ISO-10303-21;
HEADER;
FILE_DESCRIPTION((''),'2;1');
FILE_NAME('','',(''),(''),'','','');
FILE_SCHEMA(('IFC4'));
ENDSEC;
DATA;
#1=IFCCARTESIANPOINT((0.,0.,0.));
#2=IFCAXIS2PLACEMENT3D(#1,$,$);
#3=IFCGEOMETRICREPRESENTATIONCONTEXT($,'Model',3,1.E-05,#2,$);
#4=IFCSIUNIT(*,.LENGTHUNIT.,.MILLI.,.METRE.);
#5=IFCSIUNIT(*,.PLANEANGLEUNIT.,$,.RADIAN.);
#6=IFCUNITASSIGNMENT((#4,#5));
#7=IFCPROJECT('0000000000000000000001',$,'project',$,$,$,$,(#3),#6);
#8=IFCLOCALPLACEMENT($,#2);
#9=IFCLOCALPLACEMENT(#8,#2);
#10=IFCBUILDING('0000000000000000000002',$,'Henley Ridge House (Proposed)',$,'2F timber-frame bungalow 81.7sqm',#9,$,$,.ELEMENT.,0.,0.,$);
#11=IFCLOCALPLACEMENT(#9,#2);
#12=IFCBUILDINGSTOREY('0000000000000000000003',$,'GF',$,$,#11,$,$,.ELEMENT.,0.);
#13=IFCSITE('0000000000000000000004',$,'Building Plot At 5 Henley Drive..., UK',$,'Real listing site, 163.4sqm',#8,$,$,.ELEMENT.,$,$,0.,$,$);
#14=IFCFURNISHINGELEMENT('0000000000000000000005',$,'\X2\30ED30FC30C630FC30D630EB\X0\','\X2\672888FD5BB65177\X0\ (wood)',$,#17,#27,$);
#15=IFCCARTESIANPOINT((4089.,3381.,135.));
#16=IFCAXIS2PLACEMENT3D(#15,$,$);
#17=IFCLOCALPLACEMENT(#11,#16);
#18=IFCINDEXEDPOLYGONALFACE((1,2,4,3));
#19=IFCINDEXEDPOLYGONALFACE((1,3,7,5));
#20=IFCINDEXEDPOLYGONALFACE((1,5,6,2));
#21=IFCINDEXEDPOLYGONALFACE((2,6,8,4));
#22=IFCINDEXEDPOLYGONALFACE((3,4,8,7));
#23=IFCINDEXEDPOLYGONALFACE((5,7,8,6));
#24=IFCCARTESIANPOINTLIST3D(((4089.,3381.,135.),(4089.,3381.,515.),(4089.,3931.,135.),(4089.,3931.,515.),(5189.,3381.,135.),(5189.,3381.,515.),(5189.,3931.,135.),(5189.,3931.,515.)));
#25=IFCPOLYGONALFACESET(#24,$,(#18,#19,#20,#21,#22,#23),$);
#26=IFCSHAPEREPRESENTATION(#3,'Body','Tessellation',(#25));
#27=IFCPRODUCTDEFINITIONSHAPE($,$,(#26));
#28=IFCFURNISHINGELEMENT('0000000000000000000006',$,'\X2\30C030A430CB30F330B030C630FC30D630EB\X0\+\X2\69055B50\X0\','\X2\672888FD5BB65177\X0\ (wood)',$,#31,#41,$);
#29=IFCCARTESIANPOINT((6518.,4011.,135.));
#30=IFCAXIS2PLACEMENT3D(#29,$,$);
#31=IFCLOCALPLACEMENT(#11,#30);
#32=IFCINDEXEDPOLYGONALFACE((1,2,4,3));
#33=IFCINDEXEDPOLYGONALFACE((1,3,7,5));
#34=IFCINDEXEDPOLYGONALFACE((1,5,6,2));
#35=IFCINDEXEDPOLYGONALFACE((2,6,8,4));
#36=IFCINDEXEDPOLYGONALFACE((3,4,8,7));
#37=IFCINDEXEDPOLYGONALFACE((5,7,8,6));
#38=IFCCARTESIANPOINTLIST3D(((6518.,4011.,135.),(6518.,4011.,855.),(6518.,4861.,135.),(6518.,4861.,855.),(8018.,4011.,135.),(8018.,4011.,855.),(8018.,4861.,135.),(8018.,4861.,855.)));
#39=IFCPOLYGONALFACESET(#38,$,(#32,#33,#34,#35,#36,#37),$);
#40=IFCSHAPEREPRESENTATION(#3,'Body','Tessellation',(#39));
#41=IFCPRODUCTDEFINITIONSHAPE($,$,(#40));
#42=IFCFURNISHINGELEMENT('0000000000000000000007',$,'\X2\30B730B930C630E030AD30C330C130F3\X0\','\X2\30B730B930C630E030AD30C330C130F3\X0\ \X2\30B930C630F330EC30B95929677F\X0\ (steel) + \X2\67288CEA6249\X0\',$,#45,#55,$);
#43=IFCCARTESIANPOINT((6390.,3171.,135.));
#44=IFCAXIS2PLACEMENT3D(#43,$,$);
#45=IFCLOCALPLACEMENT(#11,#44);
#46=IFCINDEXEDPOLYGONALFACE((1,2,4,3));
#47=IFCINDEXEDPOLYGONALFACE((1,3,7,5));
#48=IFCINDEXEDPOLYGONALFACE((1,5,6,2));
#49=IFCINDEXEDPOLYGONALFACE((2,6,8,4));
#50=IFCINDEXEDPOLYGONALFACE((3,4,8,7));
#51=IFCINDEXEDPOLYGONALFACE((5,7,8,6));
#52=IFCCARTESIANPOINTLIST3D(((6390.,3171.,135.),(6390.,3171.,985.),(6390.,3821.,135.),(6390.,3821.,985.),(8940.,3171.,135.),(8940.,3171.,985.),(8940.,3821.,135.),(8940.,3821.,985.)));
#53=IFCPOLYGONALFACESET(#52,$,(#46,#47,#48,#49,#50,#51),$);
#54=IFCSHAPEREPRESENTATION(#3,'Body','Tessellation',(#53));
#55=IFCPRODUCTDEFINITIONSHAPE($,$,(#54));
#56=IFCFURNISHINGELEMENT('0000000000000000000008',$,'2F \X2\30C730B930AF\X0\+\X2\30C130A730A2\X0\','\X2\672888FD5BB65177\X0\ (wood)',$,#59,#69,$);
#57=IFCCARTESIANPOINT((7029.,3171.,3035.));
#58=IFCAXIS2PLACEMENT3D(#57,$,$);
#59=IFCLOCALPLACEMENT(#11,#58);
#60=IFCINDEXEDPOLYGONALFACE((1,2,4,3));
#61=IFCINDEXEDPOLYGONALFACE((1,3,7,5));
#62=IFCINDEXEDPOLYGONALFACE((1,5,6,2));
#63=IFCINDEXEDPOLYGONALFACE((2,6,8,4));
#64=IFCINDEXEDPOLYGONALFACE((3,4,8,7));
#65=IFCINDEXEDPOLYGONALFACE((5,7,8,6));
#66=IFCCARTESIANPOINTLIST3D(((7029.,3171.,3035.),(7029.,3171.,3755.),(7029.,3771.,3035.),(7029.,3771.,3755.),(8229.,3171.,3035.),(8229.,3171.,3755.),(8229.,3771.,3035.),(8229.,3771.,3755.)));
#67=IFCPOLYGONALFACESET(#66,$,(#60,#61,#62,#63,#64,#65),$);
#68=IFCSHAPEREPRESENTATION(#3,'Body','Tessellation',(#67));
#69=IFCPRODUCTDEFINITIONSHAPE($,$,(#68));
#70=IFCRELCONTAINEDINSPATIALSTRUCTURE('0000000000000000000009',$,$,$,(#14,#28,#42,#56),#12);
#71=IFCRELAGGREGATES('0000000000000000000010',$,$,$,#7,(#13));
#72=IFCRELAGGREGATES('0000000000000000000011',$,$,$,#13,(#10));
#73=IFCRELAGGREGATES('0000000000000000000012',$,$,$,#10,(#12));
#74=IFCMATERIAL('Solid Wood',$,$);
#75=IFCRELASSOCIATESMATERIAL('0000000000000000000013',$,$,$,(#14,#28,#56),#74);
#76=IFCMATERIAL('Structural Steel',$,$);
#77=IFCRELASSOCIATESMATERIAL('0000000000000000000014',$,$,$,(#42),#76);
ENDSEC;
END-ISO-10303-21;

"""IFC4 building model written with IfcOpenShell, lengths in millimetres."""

from ifc_helpers import new_model, si_unit, frame, frame_2d, origin, place, context, project, spatial, rectangle, extrude, material, element, save


model = new_model("IFC4")

# Units and contexts
model_context = context("Model", 3, precision=1e-05, world=origin())
ifc_project = project(units=[si_unit("LENGTHUNIT", "METRE", prefix="MILLI"), si_unit("PLANEANGLEUNIT", "RADIAN")], contexts=[model_context])

# Site, building, storey
site_placement = place(None, origin())
site = spatial("IfcSite", under=ifc_project, at=site_placement, Name="Building Plot At 5 Henley Drive..., UK", ObjectType="Real listing site, 163.4sqm", CompositionType="ELEMENT", RefElevation=0.0)
building_placement = place(site_placement, origin())
building = spatial("IfcBuilding", under=site, at=building_placement, Name="Henley Ridge House (Proposed)", ObjectType="2F timber-frame bungalow 81.7sqm", CompositionType="ELEMENT", ElevationOfRefHeight=0.0, ElevationOfTerrain=0.0)
storey_placement = place(building_placement, origin())
storey = spatial("IfcBuildingStorey", under=building, at=storey_placement, Name="GF", CompositionType="ELEMENT", Elevation=0.0)

# Shared definitions
ifc_material_1 = material(Name="Solid Wood")

# Shared definitions
ifc_material_2 = material(Name="Structural Steel")

# Furnishing elements
furnishing_1_placement = place(storey_placement, frame((4089.0, 3381.0, 135.0)))
element("IfcFurnishingElement", 1, at=furnishing_1_placement, inside=storey, material=ifc_material_1, Name="ローテーブル", Description="木製家具 (wood)", context=model_context, shape_type="SweptSolid", body=[
    extrude(rectangle(XDim=1100.0, YDim=550.0, at=frame_2d((550.0, 275.0))), frame((4089.0, 3381.0, 135.0)), (0.0, 0.0, 1.0), 380.0),
])
furnishing_2_placement = place(storey_placement, frame((6518.0, 4011.0, 135.0)))
element("IfcFurnishingElement", 2, at=furnishing_2_placement, inside=storey, material=ifc_material_1, Name="ダイニングテーブル+椅子", Description="木製家具 (wood)", context=model_context, shape_type="SweptSolid", body=[
    extrude(rectangle(XDim=1500.0, YDim=850.0, at=frame_2d((750.0, 425.0))), frame((6518.0, 4011.0, 135.0)), (0.0, 0.0, 1.0), 720.0),
])
furnishing_3_placement = place(storey_placement, frame((6390.0, 3171.0, 135.0)))
element("IfcFurnishingElement", 3, at=furnishing_3_placement, inside=storey, material=ifc_material_2, Name="システムキッチン", Description="システムキッチン ステンレス天板 (steel) + 木質扉", context=model_context, shape_type="SweptSolid", body=[
    extrude(rectangle(XDim=2550.0, YDim=650.0, at=frame_2d((1275.0, 325.0))), frame((6390.0, 3171.0, 135.0)), (0.0, 0.0, 1.0), 850.0),
])
furnishing_4_placement = place(storey_placement, frame((7029.0, 3171.0, 3035.0)))
element("IfcFurnishingElement", 4, at=furnishing_4_placement, inside=storey, material=ifc_material_1, Name="2F デスク+チェア", Description="木製家具 (wood)", context=model_context, shape_type="SweptSolid", body=[
    extrude(rectangle(XDim=1200.0, YDim=600.0, at=frame_2d((600.0, 300.0))), frame((7029.0, 3171.0, 3035.0)), (0.0, 0.0, 1.0), 720.0),
])

save(model, "model.ifc")
